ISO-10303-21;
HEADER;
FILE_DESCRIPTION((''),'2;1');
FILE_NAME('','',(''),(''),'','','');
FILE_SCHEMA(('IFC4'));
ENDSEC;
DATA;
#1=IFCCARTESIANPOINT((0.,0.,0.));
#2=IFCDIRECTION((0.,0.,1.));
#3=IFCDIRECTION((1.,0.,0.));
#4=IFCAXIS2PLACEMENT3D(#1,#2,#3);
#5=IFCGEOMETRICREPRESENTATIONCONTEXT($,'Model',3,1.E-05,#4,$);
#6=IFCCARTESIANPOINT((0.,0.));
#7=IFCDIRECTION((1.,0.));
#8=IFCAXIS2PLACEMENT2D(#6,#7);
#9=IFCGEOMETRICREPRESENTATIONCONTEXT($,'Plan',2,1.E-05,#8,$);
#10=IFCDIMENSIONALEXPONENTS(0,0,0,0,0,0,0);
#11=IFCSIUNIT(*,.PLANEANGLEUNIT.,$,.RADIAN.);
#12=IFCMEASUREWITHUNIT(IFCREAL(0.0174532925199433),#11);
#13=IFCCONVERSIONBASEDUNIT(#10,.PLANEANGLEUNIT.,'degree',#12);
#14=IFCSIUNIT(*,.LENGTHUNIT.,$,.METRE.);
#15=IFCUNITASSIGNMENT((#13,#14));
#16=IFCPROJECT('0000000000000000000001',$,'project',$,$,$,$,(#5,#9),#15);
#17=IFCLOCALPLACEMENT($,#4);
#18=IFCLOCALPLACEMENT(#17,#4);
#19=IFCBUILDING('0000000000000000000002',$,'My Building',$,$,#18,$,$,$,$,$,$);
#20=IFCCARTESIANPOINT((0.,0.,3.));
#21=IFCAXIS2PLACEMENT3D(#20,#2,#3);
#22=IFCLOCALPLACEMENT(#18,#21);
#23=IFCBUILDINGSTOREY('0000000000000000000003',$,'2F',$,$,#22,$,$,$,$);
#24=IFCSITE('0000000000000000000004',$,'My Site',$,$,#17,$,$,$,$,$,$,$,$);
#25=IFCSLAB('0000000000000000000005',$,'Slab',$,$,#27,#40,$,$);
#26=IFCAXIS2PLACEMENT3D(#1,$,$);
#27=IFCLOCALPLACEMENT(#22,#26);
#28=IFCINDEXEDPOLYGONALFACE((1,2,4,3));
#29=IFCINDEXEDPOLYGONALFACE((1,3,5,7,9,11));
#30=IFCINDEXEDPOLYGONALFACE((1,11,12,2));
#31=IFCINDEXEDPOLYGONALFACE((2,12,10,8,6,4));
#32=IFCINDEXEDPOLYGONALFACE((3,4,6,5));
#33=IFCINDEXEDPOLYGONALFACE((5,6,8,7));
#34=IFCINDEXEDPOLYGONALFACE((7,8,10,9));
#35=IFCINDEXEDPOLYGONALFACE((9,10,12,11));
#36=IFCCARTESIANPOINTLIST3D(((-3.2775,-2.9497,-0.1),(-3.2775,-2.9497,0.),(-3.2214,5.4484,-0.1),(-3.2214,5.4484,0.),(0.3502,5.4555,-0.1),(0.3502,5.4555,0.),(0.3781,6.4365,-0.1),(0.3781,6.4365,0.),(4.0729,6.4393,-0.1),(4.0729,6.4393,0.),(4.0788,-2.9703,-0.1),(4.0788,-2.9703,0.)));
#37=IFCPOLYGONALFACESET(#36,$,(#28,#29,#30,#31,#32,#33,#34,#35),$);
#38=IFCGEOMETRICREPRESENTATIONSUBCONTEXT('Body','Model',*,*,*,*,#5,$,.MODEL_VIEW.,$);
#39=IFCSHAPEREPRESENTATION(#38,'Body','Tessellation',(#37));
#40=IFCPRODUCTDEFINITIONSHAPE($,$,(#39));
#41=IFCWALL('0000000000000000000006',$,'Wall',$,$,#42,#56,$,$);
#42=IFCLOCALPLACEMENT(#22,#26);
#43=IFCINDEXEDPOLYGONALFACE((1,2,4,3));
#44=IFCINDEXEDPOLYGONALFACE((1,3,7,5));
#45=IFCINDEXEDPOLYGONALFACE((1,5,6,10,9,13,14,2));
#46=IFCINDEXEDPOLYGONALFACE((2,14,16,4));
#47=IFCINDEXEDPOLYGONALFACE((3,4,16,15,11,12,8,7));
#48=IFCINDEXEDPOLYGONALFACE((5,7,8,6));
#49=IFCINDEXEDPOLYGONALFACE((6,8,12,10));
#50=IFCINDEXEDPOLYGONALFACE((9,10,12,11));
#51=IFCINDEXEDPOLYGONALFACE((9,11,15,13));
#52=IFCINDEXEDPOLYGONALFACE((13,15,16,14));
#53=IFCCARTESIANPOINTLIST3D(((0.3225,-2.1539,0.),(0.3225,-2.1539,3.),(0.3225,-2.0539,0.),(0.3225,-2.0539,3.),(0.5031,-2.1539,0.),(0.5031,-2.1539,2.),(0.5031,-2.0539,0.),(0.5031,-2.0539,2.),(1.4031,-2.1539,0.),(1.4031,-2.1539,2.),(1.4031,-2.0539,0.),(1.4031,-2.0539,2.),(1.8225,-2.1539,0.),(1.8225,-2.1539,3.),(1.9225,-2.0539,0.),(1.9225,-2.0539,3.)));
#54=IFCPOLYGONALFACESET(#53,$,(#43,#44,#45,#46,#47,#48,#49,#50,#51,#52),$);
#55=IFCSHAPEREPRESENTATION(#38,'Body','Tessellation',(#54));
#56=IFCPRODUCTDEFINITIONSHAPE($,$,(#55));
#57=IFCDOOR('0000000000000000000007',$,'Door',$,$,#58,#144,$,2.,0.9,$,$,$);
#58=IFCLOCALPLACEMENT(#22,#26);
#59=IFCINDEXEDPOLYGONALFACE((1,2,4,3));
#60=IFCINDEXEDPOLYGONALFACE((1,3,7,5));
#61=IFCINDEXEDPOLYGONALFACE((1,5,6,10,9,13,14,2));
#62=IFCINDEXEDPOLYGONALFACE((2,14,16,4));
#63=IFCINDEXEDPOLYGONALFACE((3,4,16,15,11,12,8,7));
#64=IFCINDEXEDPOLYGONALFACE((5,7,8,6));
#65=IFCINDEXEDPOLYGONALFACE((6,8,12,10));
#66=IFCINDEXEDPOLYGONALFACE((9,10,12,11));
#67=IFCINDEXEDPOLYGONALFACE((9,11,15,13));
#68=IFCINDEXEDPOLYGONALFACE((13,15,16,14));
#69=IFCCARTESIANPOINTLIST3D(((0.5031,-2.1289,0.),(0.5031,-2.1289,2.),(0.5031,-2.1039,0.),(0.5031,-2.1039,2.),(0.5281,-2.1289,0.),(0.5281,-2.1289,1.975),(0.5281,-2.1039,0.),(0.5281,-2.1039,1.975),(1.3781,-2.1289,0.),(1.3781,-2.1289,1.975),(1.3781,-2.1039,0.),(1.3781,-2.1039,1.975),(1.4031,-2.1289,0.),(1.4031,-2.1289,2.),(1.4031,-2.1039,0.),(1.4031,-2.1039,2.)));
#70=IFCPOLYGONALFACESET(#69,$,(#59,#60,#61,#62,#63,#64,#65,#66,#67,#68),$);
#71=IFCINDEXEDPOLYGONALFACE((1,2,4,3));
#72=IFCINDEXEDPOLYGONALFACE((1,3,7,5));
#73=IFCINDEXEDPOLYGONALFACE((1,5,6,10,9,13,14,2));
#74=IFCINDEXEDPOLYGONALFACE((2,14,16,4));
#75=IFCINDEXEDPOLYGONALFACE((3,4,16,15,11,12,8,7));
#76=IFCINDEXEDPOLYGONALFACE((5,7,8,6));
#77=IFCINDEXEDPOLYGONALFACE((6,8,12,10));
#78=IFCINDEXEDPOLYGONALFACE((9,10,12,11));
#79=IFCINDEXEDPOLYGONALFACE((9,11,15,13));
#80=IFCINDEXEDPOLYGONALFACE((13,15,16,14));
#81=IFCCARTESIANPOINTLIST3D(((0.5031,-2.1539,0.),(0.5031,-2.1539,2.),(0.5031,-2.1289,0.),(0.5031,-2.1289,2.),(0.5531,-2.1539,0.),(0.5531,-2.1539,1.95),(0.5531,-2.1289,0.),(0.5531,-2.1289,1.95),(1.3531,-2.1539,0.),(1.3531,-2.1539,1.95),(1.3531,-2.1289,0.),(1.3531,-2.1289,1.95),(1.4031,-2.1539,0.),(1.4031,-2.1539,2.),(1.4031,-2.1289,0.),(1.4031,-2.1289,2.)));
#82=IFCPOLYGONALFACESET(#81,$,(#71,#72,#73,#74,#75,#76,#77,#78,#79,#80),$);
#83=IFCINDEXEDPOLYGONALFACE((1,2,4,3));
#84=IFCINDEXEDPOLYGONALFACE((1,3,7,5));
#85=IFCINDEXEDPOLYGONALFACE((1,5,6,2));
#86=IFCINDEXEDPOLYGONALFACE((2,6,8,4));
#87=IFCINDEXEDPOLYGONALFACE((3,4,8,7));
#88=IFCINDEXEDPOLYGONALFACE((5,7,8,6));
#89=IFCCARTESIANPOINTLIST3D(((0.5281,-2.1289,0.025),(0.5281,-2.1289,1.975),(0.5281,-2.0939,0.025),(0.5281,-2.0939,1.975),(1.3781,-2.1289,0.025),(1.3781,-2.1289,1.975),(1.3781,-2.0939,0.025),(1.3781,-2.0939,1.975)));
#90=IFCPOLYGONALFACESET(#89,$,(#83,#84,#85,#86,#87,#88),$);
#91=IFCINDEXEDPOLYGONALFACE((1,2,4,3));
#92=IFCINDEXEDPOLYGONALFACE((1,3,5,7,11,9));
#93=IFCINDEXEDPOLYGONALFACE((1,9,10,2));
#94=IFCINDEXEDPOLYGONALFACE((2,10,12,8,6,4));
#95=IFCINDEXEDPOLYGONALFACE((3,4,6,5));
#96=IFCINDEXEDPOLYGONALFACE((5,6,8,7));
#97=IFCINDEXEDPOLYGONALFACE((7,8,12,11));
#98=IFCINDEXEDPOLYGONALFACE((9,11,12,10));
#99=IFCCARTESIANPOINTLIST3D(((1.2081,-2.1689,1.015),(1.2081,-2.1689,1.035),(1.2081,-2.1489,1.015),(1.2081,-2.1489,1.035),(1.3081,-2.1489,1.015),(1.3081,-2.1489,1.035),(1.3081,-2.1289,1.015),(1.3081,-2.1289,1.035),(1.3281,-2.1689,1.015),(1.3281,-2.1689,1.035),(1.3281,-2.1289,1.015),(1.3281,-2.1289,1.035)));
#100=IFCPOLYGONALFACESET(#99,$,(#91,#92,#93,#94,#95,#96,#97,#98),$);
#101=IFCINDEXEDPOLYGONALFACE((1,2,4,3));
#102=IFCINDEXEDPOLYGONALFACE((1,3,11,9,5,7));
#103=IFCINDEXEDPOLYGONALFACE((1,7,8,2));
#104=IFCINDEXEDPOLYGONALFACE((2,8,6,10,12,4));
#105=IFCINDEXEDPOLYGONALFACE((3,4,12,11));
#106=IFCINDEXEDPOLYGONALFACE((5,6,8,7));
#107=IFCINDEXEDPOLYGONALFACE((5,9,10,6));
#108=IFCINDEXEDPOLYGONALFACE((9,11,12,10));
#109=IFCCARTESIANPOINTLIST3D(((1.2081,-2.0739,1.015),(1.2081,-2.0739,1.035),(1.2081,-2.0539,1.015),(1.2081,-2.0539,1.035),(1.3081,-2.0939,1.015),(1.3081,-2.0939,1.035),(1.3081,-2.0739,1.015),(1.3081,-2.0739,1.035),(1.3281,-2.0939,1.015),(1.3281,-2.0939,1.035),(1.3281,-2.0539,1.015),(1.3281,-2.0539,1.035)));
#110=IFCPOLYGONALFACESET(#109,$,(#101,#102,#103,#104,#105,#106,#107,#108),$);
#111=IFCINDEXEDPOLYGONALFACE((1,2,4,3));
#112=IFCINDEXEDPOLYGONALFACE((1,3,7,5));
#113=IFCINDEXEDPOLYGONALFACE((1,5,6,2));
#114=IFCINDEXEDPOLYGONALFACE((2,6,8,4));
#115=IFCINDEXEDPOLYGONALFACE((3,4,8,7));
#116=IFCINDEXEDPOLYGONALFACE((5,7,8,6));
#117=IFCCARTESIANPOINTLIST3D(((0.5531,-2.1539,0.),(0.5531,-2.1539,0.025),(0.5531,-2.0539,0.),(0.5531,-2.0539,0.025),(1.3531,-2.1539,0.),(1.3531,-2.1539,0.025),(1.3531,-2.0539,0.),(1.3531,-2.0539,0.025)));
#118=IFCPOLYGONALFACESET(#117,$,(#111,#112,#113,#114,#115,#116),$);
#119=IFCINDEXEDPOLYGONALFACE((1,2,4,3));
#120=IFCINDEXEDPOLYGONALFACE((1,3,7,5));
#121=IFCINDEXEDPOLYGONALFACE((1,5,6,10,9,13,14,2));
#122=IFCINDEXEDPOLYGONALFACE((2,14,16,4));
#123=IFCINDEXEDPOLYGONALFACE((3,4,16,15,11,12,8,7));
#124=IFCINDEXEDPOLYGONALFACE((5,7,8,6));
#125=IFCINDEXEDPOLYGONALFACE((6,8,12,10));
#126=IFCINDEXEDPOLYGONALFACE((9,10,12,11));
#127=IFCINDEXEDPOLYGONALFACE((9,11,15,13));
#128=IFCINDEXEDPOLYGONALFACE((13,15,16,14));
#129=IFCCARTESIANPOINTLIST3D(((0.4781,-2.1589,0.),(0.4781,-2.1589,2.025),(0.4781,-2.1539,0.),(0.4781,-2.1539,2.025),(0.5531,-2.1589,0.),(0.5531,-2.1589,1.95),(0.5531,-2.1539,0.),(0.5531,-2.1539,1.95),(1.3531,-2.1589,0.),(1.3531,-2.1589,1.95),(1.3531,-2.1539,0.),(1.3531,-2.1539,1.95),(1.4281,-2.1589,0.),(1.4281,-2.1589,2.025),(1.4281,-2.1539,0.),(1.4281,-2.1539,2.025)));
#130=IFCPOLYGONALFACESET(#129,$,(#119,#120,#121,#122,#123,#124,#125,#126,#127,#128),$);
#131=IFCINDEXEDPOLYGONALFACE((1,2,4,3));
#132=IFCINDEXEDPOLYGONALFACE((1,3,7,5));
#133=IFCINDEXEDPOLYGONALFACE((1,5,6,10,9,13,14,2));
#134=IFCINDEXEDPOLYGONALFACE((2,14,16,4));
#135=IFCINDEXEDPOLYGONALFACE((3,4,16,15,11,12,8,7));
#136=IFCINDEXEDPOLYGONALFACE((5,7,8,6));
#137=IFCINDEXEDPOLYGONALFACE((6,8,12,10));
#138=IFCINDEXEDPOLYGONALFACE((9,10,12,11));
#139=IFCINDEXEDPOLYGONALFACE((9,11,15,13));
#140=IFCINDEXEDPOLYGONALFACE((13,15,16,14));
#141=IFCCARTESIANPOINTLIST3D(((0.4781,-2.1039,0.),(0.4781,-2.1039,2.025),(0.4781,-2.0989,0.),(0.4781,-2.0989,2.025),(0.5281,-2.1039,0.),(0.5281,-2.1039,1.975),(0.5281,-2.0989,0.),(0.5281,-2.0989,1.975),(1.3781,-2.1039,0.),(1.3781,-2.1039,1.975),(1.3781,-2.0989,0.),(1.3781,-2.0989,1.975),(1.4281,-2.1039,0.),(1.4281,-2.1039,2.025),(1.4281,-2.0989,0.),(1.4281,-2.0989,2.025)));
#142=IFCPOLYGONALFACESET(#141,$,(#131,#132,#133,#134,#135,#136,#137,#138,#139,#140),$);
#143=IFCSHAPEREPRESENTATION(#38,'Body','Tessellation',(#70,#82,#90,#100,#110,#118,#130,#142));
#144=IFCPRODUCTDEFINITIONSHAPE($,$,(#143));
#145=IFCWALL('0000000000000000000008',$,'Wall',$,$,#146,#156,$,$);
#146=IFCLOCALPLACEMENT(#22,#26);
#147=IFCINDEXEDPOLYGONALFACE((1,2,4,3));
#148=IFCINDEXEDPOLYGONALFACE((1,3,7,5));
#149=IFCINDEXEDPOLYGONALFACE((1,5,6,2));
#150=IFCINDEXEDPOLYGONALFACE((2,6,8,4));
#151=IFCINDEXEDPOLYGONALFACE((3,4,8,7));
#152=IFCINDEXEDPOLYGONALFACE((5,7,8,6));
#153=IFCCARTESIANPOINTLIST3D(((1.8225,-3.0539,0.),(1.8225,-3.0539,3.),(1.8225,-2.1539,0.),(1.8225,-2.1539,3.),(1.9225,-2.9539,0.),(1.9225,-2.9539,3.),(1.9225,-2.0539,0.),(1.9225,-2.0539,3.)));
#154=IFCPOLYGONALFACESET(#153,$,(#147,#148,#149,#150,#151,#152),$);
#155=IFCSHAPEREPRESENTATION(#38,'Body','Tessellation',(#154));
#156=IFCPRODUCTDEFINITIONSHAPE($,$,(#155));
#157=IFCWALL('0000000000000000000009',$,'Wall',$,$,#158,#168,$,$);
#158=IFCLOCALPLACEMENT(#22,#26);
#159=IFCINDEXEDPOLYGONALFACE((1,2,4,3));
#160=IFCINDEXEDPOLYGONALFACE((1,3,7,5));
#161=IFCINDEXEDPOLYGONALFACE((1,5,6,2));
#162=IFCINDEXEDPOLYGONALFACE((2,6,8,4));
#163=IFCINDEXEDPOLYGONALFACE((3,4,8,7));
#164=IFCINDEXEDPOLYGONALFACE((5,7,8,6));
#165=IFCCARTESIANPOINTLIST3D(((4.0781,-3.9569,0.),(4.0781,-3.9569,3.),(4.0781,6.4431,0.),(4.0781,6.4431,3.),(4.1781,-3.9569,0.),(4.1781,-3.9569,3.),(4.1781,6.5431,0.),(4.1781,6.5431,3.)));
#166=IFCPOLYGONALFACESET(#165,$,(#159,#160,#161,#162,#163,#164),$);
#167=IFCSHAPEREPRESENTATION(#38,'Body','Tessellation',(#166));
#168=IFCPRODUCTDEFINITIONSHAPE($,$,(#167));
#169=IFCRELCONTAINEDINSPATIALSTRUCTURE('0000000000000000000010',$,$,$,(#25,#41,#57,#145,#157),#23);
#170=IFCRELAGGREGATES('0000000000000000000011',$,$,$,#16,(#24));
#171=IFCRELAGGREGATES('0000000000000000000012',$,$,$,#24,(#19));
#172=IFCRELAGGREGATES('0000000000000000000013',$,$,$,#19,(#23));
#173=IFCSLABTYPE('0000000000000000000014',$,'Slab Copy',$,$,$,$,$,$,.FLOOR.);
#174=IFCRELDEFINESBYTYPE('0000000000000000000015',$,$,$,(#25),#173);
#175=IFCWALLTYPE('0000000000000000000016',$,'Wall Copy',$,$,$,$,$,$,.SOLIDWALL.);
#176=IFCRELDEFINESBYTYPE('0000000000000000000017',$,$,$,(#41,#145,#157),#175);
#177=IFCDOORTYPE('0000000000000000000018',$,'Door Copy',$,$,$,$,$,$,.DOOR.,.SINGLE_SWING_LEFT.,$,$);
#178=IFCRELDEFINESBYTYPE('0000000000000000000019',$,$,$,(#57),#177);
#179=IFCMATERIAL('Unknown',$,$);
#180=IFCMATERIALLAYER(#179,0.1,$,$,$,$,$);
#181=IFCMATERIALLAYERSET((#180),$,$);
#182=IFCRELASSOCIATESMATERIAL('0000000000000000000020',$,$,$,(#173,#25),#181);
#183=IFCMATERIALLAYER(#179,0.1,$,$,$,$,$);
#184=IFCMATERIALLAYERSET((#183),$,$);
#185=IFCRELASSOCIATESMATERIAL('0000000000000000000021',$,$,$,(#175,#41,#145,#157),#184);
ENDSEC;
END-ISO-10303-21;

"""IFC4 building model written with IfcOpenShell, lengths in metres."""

from ifc_helpers import new_model, entity, si_unit, converted_unit, frame, origin_with_axes, origin_2d_with_axis, place, context, subcontext, project, spatial, line, indexed_curve, outline, extrude, shape, source, transform, mapped, material, layer, layer_set, layer_usage, type_object, type_shapes, element, fill, save


model = new_model("IFC4")

# Units and contexts
model_context = context("Model", 3, precision=1e-05, world=origin_with_axes())
plan_context = context("Plan", 2, precision=1e-05, world=origin_2d_with_axis())
body_context_1 = subcontext(model_context, "Body", "Model", "MODEL_VIEW")
body_context_2 = subcontext(plan_context, "Body", "Plan", "PLAN_VIEW")
ifc_project = project(units=[converted_unit("PLANEANGLEUNIT", "degree", entity("IfcReal", 0.0174532925199433), si_unit("PLANEANGLEUNIT", "RADIAN"), dimensions=[0, 0, 0, 0, 0, 0, 0]), si_unit("LENGTHUNIT", "METRE")], contexts=[model_context, plan_context])

# Site, building, storey
site_placement = place(None, origin_with_axes())
site = spatial("IfcSite", under=ifc_project, at=site_placement, Name="My Site")
building_placement = place(site_placement, origin_with_axes())
building = spatial("IfcBuilding", under=site, at=building_placement, Name="My Building")
storey_placement = place(building_placement, frame((0.0, 0.0, 3.0), z_axis=(0.0, 0.0, 1.0), x_axis=(1.0, 0.0, 0.0)))
storey = spatial("IfcBuildingStorey", under=building, at=storey_placement, Name="2F")

# Slab
ifc_material = material(Name="Unknown")
ifc_layer_1 = layer(ifc_material, 0.1)
ifc_layer_set_1 = layer_set([ifc_layer_1])
ifc_layer_usage_1 = layer_usage(ifc_layer_set_1, "AXIS3", "POSITIVE", -0.1)
slab_type = type_object("IfcSlabType", Name="Slab Copy", PredefinedType="FLOOR", material=ifc_layer_set_1)
slab_placement = place(storey_placement, frame((-3.2775, -2.9497, 0.0), z_axis=(0.0, 0.0, 1.0), x_axis=(1.0, 0.0, 0.0)))
element("IfcSlab", 1, at=slab_placement, inside=storey, type_object=slab_type, material=ifc_layer_usage_1, Name="Slab", context=body_context_1, shape_type="SweptSolid", body=[
    extrude(outline(indexed_curve([(0.0, 0.0), (7.3564, -0.0206), (7.3504, 9.389), (3.6556, 9.3862), (3.6278, 8.4052), (0.0561, 8.3981), (0.0, 0.0)])), frame((0.0, 0.0, -0.1), z_axis=(0.0, 0.0, 1.0), x_axis=(1.0, 0.0, 0.0)), (0.0, 0.0, 1.0), 0.1),
])

# Wall, opening, door
ifc_layer_2 = layer(ifc_material, 0.1)
ifc_layer_set_2 = layer_set([ifc_layer_2])
ifc_layer_usage_2 = layer_usage(ifc_layer_set_2, "AXIS2", "POSITIVE", 0.0)
wall_type = type_object("IfcWallType", Name="Wall Copy", PredefinedType="SOLIDWALL", material=ifc_layer_set_2)
wall_1_placement = place(storey_placement, frame((0.3225, -2.1539, 0.0), z_axis=(0.0, 0.0, 1.0), x_axis=(1.0, 0.0, 0.0)))
wall_1 = element("IfcWall", 2, at=wall_1_placement, inside=storey, type_object=wall_type, material=ifc_layer_usage_2, Name="Wall", context=body_context_1, shape_type="SweptSolid", body=[
    extrude(outline(indexed_curve([(0.0, 0.0), (0.0, 0.1), (1.6, 0.1), (1.5, 0.0)], segments=[line(1, 2, 3, 4, 1)])), origin_with_axes(), (0.0, 0.0, 1.0), 3.0),
])
shared_shape_1 = source(origin_with_axes(), body_context_1, "Body", "SweptSolid", [
    extrude(outline(indexed_curve([(0.0, 0.0), (0.9, 0.0), (0.9, 2.0), (0.0, 2.0)], segments=[line(1, 2, 3, 4, 1)])), frame((0.0, -0.6, 0.0), z_axis=(0.0, -1.0, 0.0), x_axis=(1.0, 0.0, 0.0)), (0.0, 0.0, -1.0), 1.2),
])
opening_1_placement = place(wall_1_placement, frame((0.1806, 0.0, 0.0), z_axis=(0.0, 0.0, 1.0), x_axis=(1.0, 0.0, 0.0)))
opening_1 = element("IfcOpeningElement", 3, at=opening_1_placement, cuts=wall_1, PredefinedType="OPENING", context=body_context_1, shape_type="MappedRepresentation", body=[
    mapped(shared_shape_1, transform((0.0, 0.0, 0.0), x_axis=(1.0, 0.0, 0.0), y_axis=(0.0, 1.0, 0.0), z_axis=(0.0, 0.0, 1.0), scale=1.0)),
])
door_type = type_object("IfcDoorType", Name="Door Copy", OperationType="SINGLE_SWING_LEFT", PredefinedType="DOOR")
shared_shape_2 = source(origin_with_axes(), body_context_1, "Body", "SweptSolid", [
    extrude(outline(indexed_curve([(0.0, 0.0), (0.0, 2.0), (0.9, 2.0), (0.9, 0.0), (0.875, 0.0), (0.875, 1.975), (0.025, 1.975), (0.025, 0.0)], segments=[line(1, 2, 3, 4, 5, 6, 7, 8, 1)])), frame((0.0, 0.025, 0.0), z_axis=(0.0, -1.0, 0.0), x_axis=(1.0, 0.0, 0.0)), (0.0, 0.0, -1.0), 0.025),
    extrude(outline(indexed_curve([(0.0, 0.0), (0.0, 2.0), (0.9, 2.0), (0.9, 0.0), (0.85, 0.0), (0.85, 1.95), (0.05, 1.95), (0.05, 0.0)], segments=[line(1, 2, 3, 4, 5, 6, 7, 8, 1)])), frame((0.0, 0.0, 0.0), z_axis=(0.0, -1.0, 0.0), x_axis=(1.0, 0.0, 0.0)), (0.0, 0.0, -1.0), 0.025),
    extrude(outline(indexed_curve([(0.0, 0.0), (0.85, 0.0), (0.85, 0.035), (0.0, 0.035)], segments=[line(1, 2, 3, 4, 1)])), frame((0.025, 0.025, 0.025), z_axis=(0.0, 0.0, 1.0), x_axis=(1.0, 0.0, 0.0)), (0.0, 0.0, 1.0), 1.95),
    extrude(outline(indexed_curve([(0.0, 0.0), (0.0, -0.04), (-0.12, -0.04), (-0.12, -0.02), (-0.02, -0.02), (-0.02, 0.0)], segments=[line(1, 2, 3, 4, 5, 6, 1)])), frame((0.825, 0.025, 1.015), z_axis=(0.0, 0.0, 1.0), x_axis=(1.0, 0.0, 0.0)), (0.0, 0.0, 1.0), 0.02),
    extrude(outline(indexed_curve([(0.0, 0.0), (0.0, 0.04), (-0.12, 0.04), (-0.12, 0.02), (-0.02, 0.02), (-0.02, 0.0)], segments=[line(1, 2, 3, 4, 5, 6, 1)])), frame((0.825, 0.06, 1.015), z_axis=(0.0, 0.0, 1.0), x_axis=(1.0, 0.0, 0.0)), (0.0, 0.0, 1.0), 0.02),
    extrude(outline(indexed_curve([(0.0, 0.0), (0.8, 0.0), (0.8, 0.1), (0.0, 0.1)], segments=[line(1, 2, 3, 4, 1)])), frame((0.05, 0.0, 0.0), z_axis=(0.0, 0.0, 1.0), x_axis=(1.0, 0.0, 0.0)), (0.0, 0.0, 1.0), 0.025),
    extrude(outline(indexed_curve([(0.0, 0.0), (0.0, 2.025), (0.95, 2.025), (0.95, 0.0), (0.875, 0.0), (0.875, 1.95), (0.075, 1.95), (0.075, 0.0)], segments=[line(1, 2, 3, 4, 5, 6, 7, 8, 1)])), frame((-0.025, -0.005, 0.0), z_axis=(0.0, -1.0, 0.0), x_axis=(1.0, 0.0, 0.0)), (0.0, 0.0, -1.0), 0.005),
    extrude(outline(indexed_curve([(0.0, 0.0), (0.0, 2.025), (0.95, 2.025), (0.95, 0.0), (0.9, 0.0), (0.9, 1.975), (0.05, 1.975), (0.05, 0.0)], segments=[line(1, 2, 3, 4, 5, 6, 7, 8, 1)])), frame((-0.025, 0.05, 0.0), z_axis=(0.0, -1.0, 0.0), x_axis=(1.0, 0.0, 0.0)), (0.0, 0.0, -1.0), 0.005),
])
shared_shape_3 = source(origin_with_axes(), body_context_2, "Body", "Curve2D", [
    entity("IfcIndexedPolyCurve", entity("IfcCartesianPointList2D", [[0.0, 0.0], [0.0, 0.05], [0.025, 0.05], [0.025, 0.025], [0.05, 0.025], [0.05, 0.0]]), [entity("IfcLineIndex", [1, 2, 3, 4, 5, 6, 1])]),
    entity("IfcIndexedPolyCurve", entity("IfcCartesianPointList2D", [[0.9, 0.0], [0.9, 0.05], [0.875, 0.05], [0.875, 0.025], [0.85, 0.025], [0.85, 0.0]]), [entity("IfcLineIndex", [1, 2, 3, 4, 5, 6, 1])]),
    entity("IfcTrimmedCurve", entity("IfcEllipse", entity("IfcAxis2Placement2D", entity("IfcCartesianPoint", [0.06, 0.05]), entity("IfcDirection", [1.0, 0.0])), 0.815, 0.85), [entity("IfcCartesianPoint", [0.875, 0.05])], [entity("IfcCartesianPoint", [0.06, 0.9])], True, "CARTESIAN"),
    entity("IfcIndexedPolyCurve", entity("IfcCartesianPointList2D", [[0.025, 0.05], [0.06, 0.05], [0.06, 0.9], [0.025, 0.9]]), [entity("IfcLineIndex", [1, 2, 3, 4, 1])]),
])
type_shapes(door_type, [shared_shape_2, shared_shape_3])
door_1_placement = place(opening_1_placement, origin_with_axes())
door_1 = element("IfcDoor", 4, at=door_1_placement, inside=storey, type_object=door_type, Name="Door", OverallHeight=2.0, OverallWidth=0.9, shapes=[
    shape(body_context_1, "Body", "MappedRepresentation", [mapped(shared_shape_2, transform((0.0, 0.0, 0.0), x_axis=(1.0, 0.0, 0.0), y_axis=(0.0, 1.0, 0.0), z_axis=(0.0, 0.0, 1.0), scale=1.0))]),
    shape(body_context_2, "Body", "MappedRepresentation", [mapped(shared_shape_3, transform((0.0, 0.0, 0.0), x_axis=(1.0, 0.0, 0.0), y_axis=(0.0, 1.0, 0.0), z_axis=(0.0, 0.0, 1.0), scale=1.0))]),
])
fill(opening_1, door_1)

# Walls
ifc_layer_usage_3 = layer_usage(ifc_layer_set_2, "AXIS2", "POSITIVE", 0.0)
wall_2_placement = place(storey_placement, frame((1.8225, -2.1539, 0.0), z_axis=(0.0, 0.0, 1.0), x_axis=(0.0, -1.0, 0.0)))
element("IfcWall", 5, at=wall_2_placement, inside=storey, type_object=wall_type, material=ifc_layer_usage_3, Name="Wall", context=body_context_1, shape_type="SweptSolid", body=[
    extrude(outline(indexed_curve([(0.0, 0.0), (-0.1, 0.1), (0.8, 0.1), (0.9, 0.0)], segments=[line(1, 2, 3, 4, 1)])), origin_with_axes(), (0.0, 0.0, 1.0), 3.0),
])
ifc_layer_usage_4 = layer_usage(ifc_layer_set_2, "AXIS2", "POSITIVE", 0.0)
wall_3_placement = place(storey_placement, frame((4.1781, -3.9569, 0.0), z_axis=(0.0, 0.0, 1.0), x_axis=(0.0, 1.0, 0.0)))
element("IfcWall", 6, at=wall_3_placement, inside=storey, type_object=wall_type, material=ifc_layer_usage_4, Name="Wall", context=body_context_1, shape_type="SweptSolid", body=[
    extrude(outline(indexed_curve([(0.0, 0.0), (0.0, 0.1), (10.4, 0.1), (10.5, 0.0)], segments=[line(1, 2, 3, 4, 1)])), origin_with_axes(), (0.0, 0.0, 1.0), 3.0),
])

save(model, "model.ifc")
